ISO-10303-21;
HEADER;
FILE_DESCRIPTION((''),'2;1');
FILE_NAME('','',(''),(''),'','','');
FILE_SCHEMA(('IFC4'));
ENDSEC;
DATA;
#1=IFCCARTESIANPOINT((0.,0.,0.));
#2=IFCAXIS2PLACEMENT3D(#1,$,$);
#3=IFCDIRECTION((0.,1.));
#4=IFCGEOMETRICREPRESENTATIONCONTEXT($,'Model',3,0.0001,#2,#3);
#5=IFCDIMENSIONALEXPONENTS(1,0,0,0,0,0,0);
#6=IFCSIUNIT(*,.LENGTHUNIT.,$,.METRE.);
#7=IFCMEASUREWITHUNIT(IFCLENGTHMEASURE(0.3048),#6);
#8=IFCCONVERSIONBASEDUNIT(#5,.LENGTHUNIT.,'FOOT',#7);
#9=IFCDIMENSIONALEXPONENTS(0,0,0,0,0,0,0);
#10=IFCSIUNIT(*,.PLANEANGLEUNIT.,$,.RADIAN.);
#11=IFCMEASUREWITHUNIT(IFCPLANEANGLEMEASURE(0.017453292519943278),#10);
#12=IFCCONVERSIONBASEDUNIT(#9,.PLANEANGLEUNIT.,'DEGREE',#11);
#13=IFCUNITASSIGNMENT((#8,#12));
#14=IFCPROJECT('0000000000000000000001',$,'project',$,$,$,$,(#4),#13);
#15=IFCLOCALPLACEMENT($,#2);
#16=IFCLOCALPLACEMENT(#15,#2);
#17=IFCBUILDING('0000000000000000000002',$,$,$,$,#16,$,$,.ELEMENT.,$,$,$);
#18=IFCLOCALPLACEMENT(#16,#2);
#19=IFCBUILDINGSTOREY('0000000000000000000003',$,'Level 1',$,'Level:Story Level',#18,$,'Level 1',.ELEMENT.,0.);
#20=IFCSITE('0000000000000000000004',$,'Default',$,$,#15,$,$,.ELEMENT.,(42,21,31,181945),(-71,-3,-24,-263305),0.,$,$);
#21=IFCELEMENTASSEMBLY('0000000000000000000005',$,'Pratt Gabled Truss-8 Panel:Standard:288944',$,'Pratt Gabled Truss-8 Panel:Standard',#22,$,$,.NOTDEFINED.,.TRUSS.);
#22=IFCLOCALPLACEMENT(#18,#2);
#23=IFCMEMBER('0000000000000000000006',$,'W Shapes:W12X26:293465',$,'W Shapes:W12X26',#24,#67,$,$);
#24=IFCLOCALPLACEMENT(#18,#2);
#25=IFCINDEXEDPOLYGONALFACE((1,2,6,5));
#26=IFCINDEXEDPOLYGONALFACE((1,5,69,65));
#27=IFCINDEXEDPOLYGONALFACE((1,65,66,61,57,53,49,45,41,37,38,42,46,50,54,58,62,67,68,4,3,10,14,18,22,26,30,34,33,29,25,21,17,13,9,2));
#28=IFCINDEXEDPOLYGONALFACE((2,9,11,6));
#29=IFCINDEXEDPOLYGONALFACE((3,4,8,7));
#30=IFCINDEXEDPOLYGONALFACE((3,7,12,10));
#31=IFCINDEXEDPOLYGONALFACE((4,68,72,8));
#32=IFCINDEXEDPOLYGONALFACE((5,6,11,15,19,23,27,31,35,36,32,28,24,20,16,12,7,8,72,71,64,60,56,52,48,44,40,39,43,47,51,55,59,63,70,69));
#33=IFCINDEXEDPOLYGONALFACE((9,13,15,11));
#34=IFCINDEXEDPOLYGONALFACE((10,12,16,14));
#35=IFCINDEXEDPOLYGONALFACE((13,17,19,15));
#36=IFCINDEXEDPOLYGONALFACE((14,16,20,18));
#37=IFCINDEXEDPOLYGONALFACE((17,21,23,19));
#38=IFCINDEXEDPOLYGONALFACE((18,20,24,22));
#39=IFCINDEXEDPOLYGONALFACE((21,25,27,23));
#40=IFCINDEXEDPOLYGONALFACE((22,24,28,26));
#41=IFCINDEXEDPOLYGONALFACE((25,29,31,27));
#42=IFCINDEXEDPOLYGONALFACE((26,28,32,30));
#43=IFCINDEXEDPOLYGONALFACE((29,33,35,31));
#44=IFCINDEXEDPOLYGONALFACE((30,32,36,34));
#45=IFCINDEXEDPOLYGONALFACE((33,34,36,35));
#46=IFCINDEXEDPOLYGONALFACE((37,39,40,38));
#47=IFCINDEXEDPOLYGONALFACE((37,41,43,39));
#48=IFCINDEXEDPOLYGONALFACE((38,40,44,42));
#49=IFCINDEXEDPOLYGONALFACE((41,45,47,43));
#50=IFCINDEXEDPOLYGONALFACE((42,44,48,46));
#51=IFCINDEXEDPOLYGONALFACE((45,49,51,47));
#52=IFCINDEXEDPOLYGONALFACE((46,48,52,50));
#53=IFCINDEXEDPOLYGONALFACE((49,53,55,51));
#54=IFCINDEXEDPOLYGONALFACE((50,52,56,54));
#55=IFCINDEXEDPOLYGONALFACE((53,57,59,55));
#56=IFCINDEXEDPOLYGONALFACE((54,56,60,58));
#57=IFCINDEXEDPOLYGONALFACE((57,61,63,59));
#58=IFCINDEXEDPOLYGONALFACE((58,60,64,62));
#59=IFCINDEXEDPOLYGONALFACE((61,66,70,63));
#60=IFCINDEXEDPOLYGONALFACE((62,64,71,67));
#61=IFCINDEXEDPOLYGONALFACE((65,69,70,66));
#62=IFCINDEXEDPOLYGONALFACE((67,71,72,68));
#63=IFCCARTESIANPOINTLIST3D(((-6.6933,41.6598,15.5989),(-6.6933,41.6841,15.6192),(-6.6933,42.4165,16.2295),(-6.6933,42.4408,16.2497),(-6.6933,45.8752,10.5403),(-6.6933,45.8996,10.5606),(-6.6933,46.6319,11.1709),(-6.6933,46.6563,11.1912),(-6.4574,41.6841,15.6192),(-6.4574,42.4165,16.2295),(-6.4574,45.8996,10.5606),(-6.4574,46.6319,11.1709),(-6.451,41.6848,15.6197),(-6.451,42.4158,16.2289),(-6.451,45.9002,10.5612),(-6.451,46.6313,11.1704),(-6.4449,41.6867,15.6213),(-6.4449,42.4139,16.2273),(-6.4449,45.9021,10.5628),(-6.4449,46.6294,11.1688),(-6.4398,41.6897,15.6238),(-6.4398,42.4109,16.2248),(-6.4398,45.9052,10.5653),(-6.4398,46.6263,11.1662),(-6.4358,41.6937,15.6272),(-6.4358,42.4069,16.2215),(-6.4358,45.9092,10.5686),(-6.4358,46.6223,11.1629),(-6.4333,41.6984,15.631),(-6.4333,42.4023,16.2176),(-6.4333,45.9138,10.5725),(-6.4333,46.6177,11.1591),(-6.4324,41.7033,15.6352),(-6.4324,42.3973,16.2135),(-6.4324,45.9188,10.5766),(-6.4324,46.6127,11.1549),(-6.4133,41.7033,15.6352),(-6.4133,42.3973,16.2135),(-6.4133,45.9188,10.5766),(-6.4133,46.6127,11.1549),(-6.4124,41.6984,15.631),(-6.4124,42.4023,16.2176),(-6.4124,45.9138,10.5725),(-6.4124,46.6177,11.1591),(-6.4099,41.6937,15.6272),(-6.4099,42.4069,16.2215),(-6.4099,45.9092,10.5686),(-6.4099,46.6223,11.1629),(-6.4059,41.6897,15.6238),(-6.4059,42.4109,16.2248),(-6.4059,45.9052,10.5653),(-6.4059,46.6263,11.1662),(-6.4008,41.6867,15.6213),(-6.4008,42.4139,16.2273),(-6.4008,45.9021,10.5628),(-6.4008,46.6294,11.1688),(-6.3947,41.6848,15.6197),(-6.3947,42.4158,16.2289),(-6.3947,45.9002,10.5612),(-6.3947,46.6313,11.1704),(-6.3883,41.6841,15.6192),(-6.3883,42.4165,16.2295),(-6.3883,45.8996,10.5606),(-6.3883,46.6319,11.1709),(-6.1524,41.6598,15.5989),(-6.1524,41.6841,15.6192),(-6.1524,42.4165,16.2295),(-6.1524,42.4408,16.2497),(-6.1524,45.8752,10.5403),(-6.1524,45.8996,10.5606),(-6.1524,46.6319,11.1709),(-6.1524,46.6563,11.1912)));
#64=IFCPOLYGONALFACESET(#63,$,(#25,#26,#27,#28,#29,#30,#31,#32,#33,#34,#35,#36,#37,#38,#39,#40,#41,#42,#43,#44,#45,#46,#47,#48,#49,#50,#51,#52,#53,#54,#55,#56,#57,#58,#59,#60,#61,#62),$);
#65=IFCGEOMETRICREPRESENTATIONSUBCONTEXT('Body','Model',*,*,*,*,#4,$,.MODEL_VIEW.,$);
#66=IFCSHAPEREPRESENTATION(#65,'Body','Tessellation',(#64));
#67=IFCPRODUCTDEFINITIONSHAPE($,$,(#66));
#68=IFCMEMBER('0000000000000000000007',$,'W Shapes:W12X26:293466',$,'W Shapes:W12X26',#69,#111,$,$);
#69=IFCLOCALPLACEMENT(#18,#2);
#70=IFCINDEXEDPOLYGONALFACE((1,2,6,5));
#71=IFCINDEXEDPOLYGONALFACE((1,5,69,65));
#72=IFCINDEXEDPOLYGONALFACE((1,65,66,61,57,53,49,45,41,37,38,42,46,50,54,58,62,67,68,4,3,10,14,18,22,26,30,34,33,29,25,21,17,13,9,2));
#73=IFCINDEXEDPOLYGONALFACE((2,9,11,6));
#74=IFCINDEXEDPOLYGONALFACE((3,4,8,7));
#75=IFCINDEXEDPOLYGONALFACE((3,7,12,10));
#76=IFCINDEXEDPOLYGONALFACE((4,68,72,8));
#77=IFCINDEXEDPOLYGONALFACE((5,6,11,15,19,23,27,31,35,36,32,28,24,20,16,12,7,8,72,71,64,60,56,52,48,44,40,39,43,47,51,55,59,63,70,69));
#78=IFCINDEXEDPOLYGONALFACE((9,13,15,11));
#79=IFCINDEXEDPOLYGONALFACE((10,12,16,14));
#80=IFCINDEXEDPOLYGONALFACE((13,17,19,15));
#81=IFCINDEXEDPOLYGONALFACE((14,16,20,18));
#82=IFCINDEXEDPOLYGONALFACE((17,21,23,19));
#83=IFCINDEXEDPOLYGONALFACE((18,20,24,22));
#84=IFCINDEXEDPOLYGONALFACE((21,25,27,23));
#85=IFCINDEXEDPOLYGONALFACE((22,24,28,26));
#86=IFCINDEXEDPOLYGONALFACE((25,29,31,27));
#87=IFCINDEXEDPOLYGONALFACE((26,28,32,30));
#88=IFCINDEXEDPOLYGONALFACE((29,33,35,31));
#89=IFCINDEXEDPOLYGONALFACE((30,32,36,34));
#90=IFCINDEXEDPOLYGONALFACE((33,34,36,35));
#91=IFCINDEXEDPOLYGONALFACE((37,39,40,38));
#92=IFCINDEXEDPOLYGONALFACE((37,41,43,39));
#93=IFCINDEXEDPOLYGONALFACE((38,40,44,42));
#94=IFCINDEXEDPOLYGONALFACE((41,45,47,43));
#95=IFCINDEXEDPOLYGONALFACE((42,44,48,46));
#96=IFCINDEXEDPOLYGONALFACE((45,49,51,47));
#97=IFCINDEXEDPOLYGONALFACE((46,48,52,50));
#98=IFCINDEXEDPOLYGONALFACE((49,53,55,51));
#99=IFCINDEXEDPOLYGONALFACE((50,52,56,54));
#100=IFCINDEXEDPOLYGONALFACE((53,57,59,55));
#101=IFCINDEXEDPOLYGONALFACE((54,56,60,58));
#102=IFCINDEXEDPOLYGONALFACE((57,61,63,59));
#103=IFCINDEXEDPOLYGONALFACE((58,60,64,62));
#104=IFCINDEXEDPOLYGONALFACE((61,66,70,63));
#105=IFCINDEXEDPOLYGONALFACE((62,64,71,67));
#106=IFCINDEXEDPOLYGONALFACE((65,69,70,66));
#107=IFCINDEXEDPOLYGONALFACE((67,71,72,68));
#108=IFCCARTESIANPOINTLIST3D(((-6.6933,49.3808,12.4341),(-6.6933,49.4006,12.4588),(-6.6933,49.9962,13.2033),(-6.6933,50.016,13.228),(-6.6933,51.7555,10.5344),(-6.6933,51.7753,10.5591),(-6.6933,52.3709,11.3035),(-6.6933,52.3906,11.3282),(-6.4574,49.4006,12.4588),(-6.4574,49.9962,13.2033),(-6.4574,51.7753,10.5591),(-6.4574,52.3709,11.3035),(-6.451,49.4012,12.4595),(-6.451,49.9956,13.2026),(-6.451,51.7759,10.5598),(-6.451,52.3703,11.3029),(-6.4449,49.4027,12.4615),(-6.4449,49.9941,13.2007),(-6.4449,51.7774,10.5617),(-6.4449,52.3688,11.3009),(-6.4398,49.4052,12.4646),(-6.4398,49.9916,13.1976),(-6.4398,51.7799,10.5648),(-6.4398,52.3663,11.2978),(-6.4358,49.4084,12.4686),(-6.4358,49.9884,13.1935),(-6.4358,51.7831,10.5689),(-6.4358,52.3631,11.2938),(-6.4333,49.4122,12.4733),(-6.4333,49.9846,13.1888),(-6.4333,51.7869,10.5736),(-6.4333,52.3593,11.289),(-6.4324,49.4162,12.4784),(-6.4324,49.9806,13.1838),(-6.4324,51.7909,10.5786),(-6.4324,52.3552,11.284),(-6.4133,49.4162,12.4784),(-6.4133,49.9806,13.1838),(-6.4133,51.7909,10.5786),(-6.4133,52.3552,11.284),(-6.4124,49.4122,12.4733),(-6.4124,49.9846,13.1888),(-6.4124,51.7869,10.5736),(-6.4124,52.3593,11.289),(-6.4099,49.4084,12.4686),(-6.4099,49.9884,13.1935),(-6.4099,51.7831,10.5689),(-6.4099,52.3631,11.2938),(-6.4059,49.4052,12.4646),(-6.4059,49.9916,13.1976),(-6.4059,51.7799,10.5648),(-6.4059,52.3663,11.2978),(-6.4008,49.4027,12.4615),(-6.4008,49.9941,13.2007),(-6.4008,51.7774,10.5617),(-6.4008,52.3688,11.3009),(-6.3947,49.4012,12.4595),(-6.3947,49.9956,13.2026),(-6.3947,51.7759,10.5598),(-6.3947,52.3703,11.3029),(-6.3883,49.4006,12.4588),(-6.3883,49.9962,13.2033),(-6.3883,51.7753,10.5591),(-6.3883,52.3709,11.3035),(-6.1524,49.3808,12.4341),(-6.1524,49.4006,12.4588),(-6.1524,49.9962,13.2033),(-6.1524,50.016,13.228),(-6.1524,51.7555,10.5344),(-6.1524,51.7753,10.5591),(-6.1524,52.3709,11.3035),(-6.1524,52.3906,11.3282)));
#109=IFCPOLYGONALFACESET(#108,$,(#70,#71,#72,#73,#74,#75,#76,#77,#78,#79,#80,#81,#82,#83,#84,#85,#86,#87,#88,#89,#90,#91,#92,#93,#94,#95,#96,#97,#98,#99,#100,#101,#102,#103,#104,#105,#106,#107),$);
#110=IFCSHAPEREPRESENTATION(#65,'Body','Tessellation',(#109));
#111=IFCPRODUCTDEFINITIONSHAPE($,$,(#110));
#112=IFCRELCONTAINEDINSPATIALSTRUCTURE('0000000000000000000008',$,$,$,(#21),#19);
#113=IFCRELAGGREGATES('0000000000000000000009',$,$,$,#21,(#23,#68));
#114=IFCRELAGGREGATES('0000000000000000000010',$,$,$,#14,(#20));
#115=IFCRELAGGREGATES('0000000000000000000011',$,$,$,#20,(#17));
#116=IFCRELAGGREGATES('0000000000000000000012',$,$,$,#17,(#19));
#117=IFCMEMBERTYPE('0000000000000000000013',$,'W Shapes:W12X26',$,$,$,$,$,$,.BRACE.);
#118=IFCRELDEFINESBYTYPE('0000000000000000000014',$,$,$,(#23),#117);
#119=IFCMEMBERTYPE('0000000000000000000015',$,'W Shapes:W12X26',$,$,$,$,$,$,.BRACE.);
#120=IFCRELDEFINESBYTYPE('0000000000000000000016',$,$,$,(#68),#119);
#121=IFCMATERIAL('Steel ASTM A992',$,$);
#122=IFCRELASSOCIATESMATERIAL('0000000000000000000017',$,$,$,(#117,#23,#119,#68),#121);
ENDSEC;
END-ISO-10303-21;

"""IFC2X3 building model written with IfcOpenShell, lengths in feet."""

from ifc_helpers import new_model, entity, si_unit, converted_unit, direction, frame, frame_2d, origin, place, context, subcontext, project, spatial, polyline, circle_curve, parameter, trimmed, segment, composite_curve, outline, extrude, source, transform, mapped, material, type_object, type_shapes, element, aggregate, save


model = new_model("IFC2X3")

# Units and contexts
model_context = context("Model", 3, precision=0.0001, world=origin(), true_north=direction((0.0, 1.0)))
body_context = subcontext(model_context, "Body", "Model", "MODEL_VIEW")
ifc_project = project(units=[converted_unit("LENGTHUNIT", "FOOT", entity("IfcLengthMeasure", 0.3048), si_unit("LENGTHUNIT", "METRE"), dimensions=[1, 0, 0, 0, 0, 0, 0]), converted_unit("PLANEANGLEUNIT", "DEGREE", entity("IfcPlaneAngleMeasure", 0.017453292519943278), si_unit("PLANEANGLEUNIT", "RADIAN"), dimensions=[0, 0, 0, 0, 0, 0, 0])], contexts=[model_context])

# Site, building, storey
site_placement = place(None, origin())
site = spatial("IfcSite", under=ifc_project, at=site_placement, Name="Default", CompositionType="ELEMENT", RefLatitude=(42, 21, 31, 181945), RefLongitude=(-71, -3, -24, -263305), RefElevation=0.0)
building_placement = place(site_placement, origin())
building = spatial("IfcBuilding", under=site, at=building_placement, CompositionType="ELEMENT")
storey_placement = place(building_placement, origin())
storey = spatial("IfcBuildingStorey", under=building, at=storey_placement, Name="Level 1", ObjectType="Level:Story Level", LongName="Level 1", CompositionType="ELEMENT", Elevation=0.0)

# Element assembly, members
assembly_placement = place(storey_placement, origin())
assembly = element("IfcElementAssembly", 1, at=assembly_placement, inside=storey, Name="Pratt Gabled Truss-8 Panel:Standard:288944", ObjectType="Pratt Gabled Truss-8 Panel:Standard", AssemblyPlace="NOTDEFINED", PredefinedType="TRUSS")
ifc_material = material(Name="Steel ASTM A992")
member_type_1 = type_object("IfcMemberType", Name="W Shapes:W12X26", PredefinedType="BRACE", material=ifc_material)
shared_shape_1 = source(origin(), body_context, "Body", "SweptSolid", [
    extrude(outline(composite_curve([segment(polyline([(-0.2704, -0.4767), (-0.2704, -0.5083)]), True, "CONTINUOUS"), segment(polyline([(-0.2704, -0.5083), (0.2704, -0.5083)]), True, "CONTINUOUS"), segment(polyline([(0.2704, -0.5083), (0.2704, -0.4767)]), True, "CONTINUOUS"), segment(polyline([(0.2704, -0.4767), (0.0346, -0.4767)]), True, "CONTINUOUS"), segment(trimmed(circle_curve(frame_2d((0.0346, -0.4517), x_axis=(1.0, 0.0)), 0.025), [parameter(180.0)], [parameter(270.0)], True, "PARAMETER"), False, "CONTINUOUS"), segment(polyline([(0.0096, -0.4517), (0.0096, 0.4517)]), True, "CONTINUOUS"), segment(trimmed(circle_curve(frame_2d((0.0346, 0.4517), x_axis=(1.0, 0.0)), 0.025), [parameter(90.0)], [parameter(180.0)], True, "PARAMETER"), False, "CONTINUOUS"), segment(polyline([(0.0346, 0.4767), (0.2704, 0.4767)]), True, "CONTINUOUS"), segment(polyline([(0.2704, 0.4767), (0.2704, 0.5083)]), True, "CONTINUOUS"), segment(polyline([(0.2704, 0.5083), (-0.2704, 0.5083)]), True, "CONTINUOUS"), segment(polyline([(-0.2704, 0.5083), (-0.2704, 0.4767)]), True, "CONTINUOUS"), segment(polyline([(-0.2704, 0.4767), (-0.0346, 0.4767)]), True, "CONTINUOUS"), segment(trimmed(circle_curve(frame_2d((-0.0346, 0.4517), x_axis=(1.0, 0.0)), 0.025), [parameter(360.0)], [parameter(90.0)], True, "PARAMETER"), False, "CONTINUOUS"), segment(polyline([(-0.0096, 0.4517), (-0.0096, -0.4517)]), True, "CONTINUOUS"), segment(trimmed(circle_curve(frame_2d((-0.0346, -0.4517), x_axis=(1.0, 0.0)), 0.025), [parameter(270.0)], [parameter(360.0)], True, "PARAMETER"), False, "CONTINUOUS"), segment(polyline([(-0.0346, -0.4767), (-0.2704, -0.4767)]), True, "CONTINUOUS")], self_intersect=False)), frame((-2.8303, 0.0, 0.0), z_axis=(-1.0, 0.0, 0.0), x_axis=(0.0, -1.0, 0.0)), (0.0, 0.0, -1.0), 6.5847),
])
type_shapes(member_type_1, [shared_shape_1])
member_1_placement = place(assembly_placement, frame((-6.4228, 43.8622, 13.75), z_axis=(0.0, -0.768221, -0.640184), x_axis=(0.0, 0.640184, -0.768221)))
member_1 = element("IfcMember", 2, at=member_1_placement, type_object=member_type_1, material=ifc_material, Name="W Shapes:W12X26:293465", ObjectType="W Shapes:W12X26", context=body_context, shape_type="MappedRepresentation", body=[
    mapped(shared_shape_1, transform((0.0, 0.0, 0.0), scale=1.0)),
])
member_type_2 = type_object("IfcMemberType", Name="W Shapes:W12X26", PredefinedType="BRACE", material=ifc_material)
shared_shape_2 = source(origin(), body_context, "Body", "SweptSolid", [
    extrude(outline(composite_curve([segment(polyline([(-0.2704, -0.4767), (-0.2704, -0.5083)]), True, "CONTINUOUS"), segment(polyline([(-0.2704, -0.5083), (0.2704, -0.5083)]), True, "CONTINUOUS"), segment(polyline([(0.2704, -0.5083), (0.2704, -0.4767)]), True, "CONTINUOUS"), segment(polyline([(0.2704, -0.4767), (0.0346, -0.4767)]), True, "CONTINUOUS"), segment(trimmed(circle_curve(frame_2d((0.0346, -0.4517), x_axis=(1.0, 0.0)), 0.025), [parameter(180.0)], [parameter(270.0)], True, "PARAMETER"), False, "CONTINUOUS"), segment(polyline([(0.0096, -0.4517), (0.0096, 0.4517)]), True, "CONTINUOUS"), segment(trimmed(circle_curve(frame_2d((0.0346, 0.4517), x_axis=(1.0, 0.0)), 0.025), [parameter(90.0)], [parameter(180.0)], True, "PARAMETER"), False, "CONTINUOUS"), segment(polyline([(0.0346, 0.4767), (0.2704, 0.4767)]), True, "CONTINUOUS"), segment(polyline([(0.2704, 0.4767), (0.2704, 0.5083)]), True, "CONTINUOUS"), segment(polyline([(0.2704, 0.5083), (-0.2704, 0.5083)]), True, "CONTINUOUS"), segment(polyline([(-0.2704, 0.5083), (-0.2704, 0.4767)]), True, "CONTINUOUS"), segment(polyline([(-0.2704, 0.4767), (-0.0346, 0.4767)]), True, "CONTINUOUS"), segment(trimmed(circle_curve(frame_2d((-0.0346, 0.4517), x_axis=(1.0, 0.0)), 0.025), [parameter(360.0)], [parameter(90.0)], True, "PARAMETER"), False, "CONTINUOUS"), segment(polyline([(-0.0096, 0.4517), (-0.0096, -0.4517)]), True, "CONTINUOUS"), segment(trimmed(circle_curve(frame_2d((-0.0346, -0.4517), x_axis=(1.0, 0.0)), 0.025), [parameter(270.0)], [parameter(360.0)], True, "PARAMETER"), False, "CONTINUOUS"), segment(polyline([(-0.0346, -0.4767), (-0.2704, -0.4767)]), True, "CONTINUOUS")], self_intersect=False)), frame((-0.53, 0.0, 0.0), z_axis=(-1.0, 0.0, 0.0), x_axis=(0.0, -1.0, 0.0)), (0.0, 0.0, -1.0), 3.0411),
])
type_shapes(member_type_2, [shared_shape_2])
member_2_placement = place(assembly_placement, frame((-6.4228, 50.1122, 12.5), z_axis=(0.0, -0.624695, -0.780869), x_axis=(0.0, 0.780869, -0.624695)))
member_2 = element("IfcMember", 3, at=member_2_placement, type_object=member_type_2, material=ifc_material, Name="W Shapes:W12X26:293466", ObjectType="W Shapes:W12X26", context=body_context, shape_type="MappedRepresentation", body=[
    mapped(shared_shape_2, transform((0.0, 0.0, 0.0), scale=1.0)),
])
aggregate(assembly, [member_1, member_2])

save(model, "model.ifc")
